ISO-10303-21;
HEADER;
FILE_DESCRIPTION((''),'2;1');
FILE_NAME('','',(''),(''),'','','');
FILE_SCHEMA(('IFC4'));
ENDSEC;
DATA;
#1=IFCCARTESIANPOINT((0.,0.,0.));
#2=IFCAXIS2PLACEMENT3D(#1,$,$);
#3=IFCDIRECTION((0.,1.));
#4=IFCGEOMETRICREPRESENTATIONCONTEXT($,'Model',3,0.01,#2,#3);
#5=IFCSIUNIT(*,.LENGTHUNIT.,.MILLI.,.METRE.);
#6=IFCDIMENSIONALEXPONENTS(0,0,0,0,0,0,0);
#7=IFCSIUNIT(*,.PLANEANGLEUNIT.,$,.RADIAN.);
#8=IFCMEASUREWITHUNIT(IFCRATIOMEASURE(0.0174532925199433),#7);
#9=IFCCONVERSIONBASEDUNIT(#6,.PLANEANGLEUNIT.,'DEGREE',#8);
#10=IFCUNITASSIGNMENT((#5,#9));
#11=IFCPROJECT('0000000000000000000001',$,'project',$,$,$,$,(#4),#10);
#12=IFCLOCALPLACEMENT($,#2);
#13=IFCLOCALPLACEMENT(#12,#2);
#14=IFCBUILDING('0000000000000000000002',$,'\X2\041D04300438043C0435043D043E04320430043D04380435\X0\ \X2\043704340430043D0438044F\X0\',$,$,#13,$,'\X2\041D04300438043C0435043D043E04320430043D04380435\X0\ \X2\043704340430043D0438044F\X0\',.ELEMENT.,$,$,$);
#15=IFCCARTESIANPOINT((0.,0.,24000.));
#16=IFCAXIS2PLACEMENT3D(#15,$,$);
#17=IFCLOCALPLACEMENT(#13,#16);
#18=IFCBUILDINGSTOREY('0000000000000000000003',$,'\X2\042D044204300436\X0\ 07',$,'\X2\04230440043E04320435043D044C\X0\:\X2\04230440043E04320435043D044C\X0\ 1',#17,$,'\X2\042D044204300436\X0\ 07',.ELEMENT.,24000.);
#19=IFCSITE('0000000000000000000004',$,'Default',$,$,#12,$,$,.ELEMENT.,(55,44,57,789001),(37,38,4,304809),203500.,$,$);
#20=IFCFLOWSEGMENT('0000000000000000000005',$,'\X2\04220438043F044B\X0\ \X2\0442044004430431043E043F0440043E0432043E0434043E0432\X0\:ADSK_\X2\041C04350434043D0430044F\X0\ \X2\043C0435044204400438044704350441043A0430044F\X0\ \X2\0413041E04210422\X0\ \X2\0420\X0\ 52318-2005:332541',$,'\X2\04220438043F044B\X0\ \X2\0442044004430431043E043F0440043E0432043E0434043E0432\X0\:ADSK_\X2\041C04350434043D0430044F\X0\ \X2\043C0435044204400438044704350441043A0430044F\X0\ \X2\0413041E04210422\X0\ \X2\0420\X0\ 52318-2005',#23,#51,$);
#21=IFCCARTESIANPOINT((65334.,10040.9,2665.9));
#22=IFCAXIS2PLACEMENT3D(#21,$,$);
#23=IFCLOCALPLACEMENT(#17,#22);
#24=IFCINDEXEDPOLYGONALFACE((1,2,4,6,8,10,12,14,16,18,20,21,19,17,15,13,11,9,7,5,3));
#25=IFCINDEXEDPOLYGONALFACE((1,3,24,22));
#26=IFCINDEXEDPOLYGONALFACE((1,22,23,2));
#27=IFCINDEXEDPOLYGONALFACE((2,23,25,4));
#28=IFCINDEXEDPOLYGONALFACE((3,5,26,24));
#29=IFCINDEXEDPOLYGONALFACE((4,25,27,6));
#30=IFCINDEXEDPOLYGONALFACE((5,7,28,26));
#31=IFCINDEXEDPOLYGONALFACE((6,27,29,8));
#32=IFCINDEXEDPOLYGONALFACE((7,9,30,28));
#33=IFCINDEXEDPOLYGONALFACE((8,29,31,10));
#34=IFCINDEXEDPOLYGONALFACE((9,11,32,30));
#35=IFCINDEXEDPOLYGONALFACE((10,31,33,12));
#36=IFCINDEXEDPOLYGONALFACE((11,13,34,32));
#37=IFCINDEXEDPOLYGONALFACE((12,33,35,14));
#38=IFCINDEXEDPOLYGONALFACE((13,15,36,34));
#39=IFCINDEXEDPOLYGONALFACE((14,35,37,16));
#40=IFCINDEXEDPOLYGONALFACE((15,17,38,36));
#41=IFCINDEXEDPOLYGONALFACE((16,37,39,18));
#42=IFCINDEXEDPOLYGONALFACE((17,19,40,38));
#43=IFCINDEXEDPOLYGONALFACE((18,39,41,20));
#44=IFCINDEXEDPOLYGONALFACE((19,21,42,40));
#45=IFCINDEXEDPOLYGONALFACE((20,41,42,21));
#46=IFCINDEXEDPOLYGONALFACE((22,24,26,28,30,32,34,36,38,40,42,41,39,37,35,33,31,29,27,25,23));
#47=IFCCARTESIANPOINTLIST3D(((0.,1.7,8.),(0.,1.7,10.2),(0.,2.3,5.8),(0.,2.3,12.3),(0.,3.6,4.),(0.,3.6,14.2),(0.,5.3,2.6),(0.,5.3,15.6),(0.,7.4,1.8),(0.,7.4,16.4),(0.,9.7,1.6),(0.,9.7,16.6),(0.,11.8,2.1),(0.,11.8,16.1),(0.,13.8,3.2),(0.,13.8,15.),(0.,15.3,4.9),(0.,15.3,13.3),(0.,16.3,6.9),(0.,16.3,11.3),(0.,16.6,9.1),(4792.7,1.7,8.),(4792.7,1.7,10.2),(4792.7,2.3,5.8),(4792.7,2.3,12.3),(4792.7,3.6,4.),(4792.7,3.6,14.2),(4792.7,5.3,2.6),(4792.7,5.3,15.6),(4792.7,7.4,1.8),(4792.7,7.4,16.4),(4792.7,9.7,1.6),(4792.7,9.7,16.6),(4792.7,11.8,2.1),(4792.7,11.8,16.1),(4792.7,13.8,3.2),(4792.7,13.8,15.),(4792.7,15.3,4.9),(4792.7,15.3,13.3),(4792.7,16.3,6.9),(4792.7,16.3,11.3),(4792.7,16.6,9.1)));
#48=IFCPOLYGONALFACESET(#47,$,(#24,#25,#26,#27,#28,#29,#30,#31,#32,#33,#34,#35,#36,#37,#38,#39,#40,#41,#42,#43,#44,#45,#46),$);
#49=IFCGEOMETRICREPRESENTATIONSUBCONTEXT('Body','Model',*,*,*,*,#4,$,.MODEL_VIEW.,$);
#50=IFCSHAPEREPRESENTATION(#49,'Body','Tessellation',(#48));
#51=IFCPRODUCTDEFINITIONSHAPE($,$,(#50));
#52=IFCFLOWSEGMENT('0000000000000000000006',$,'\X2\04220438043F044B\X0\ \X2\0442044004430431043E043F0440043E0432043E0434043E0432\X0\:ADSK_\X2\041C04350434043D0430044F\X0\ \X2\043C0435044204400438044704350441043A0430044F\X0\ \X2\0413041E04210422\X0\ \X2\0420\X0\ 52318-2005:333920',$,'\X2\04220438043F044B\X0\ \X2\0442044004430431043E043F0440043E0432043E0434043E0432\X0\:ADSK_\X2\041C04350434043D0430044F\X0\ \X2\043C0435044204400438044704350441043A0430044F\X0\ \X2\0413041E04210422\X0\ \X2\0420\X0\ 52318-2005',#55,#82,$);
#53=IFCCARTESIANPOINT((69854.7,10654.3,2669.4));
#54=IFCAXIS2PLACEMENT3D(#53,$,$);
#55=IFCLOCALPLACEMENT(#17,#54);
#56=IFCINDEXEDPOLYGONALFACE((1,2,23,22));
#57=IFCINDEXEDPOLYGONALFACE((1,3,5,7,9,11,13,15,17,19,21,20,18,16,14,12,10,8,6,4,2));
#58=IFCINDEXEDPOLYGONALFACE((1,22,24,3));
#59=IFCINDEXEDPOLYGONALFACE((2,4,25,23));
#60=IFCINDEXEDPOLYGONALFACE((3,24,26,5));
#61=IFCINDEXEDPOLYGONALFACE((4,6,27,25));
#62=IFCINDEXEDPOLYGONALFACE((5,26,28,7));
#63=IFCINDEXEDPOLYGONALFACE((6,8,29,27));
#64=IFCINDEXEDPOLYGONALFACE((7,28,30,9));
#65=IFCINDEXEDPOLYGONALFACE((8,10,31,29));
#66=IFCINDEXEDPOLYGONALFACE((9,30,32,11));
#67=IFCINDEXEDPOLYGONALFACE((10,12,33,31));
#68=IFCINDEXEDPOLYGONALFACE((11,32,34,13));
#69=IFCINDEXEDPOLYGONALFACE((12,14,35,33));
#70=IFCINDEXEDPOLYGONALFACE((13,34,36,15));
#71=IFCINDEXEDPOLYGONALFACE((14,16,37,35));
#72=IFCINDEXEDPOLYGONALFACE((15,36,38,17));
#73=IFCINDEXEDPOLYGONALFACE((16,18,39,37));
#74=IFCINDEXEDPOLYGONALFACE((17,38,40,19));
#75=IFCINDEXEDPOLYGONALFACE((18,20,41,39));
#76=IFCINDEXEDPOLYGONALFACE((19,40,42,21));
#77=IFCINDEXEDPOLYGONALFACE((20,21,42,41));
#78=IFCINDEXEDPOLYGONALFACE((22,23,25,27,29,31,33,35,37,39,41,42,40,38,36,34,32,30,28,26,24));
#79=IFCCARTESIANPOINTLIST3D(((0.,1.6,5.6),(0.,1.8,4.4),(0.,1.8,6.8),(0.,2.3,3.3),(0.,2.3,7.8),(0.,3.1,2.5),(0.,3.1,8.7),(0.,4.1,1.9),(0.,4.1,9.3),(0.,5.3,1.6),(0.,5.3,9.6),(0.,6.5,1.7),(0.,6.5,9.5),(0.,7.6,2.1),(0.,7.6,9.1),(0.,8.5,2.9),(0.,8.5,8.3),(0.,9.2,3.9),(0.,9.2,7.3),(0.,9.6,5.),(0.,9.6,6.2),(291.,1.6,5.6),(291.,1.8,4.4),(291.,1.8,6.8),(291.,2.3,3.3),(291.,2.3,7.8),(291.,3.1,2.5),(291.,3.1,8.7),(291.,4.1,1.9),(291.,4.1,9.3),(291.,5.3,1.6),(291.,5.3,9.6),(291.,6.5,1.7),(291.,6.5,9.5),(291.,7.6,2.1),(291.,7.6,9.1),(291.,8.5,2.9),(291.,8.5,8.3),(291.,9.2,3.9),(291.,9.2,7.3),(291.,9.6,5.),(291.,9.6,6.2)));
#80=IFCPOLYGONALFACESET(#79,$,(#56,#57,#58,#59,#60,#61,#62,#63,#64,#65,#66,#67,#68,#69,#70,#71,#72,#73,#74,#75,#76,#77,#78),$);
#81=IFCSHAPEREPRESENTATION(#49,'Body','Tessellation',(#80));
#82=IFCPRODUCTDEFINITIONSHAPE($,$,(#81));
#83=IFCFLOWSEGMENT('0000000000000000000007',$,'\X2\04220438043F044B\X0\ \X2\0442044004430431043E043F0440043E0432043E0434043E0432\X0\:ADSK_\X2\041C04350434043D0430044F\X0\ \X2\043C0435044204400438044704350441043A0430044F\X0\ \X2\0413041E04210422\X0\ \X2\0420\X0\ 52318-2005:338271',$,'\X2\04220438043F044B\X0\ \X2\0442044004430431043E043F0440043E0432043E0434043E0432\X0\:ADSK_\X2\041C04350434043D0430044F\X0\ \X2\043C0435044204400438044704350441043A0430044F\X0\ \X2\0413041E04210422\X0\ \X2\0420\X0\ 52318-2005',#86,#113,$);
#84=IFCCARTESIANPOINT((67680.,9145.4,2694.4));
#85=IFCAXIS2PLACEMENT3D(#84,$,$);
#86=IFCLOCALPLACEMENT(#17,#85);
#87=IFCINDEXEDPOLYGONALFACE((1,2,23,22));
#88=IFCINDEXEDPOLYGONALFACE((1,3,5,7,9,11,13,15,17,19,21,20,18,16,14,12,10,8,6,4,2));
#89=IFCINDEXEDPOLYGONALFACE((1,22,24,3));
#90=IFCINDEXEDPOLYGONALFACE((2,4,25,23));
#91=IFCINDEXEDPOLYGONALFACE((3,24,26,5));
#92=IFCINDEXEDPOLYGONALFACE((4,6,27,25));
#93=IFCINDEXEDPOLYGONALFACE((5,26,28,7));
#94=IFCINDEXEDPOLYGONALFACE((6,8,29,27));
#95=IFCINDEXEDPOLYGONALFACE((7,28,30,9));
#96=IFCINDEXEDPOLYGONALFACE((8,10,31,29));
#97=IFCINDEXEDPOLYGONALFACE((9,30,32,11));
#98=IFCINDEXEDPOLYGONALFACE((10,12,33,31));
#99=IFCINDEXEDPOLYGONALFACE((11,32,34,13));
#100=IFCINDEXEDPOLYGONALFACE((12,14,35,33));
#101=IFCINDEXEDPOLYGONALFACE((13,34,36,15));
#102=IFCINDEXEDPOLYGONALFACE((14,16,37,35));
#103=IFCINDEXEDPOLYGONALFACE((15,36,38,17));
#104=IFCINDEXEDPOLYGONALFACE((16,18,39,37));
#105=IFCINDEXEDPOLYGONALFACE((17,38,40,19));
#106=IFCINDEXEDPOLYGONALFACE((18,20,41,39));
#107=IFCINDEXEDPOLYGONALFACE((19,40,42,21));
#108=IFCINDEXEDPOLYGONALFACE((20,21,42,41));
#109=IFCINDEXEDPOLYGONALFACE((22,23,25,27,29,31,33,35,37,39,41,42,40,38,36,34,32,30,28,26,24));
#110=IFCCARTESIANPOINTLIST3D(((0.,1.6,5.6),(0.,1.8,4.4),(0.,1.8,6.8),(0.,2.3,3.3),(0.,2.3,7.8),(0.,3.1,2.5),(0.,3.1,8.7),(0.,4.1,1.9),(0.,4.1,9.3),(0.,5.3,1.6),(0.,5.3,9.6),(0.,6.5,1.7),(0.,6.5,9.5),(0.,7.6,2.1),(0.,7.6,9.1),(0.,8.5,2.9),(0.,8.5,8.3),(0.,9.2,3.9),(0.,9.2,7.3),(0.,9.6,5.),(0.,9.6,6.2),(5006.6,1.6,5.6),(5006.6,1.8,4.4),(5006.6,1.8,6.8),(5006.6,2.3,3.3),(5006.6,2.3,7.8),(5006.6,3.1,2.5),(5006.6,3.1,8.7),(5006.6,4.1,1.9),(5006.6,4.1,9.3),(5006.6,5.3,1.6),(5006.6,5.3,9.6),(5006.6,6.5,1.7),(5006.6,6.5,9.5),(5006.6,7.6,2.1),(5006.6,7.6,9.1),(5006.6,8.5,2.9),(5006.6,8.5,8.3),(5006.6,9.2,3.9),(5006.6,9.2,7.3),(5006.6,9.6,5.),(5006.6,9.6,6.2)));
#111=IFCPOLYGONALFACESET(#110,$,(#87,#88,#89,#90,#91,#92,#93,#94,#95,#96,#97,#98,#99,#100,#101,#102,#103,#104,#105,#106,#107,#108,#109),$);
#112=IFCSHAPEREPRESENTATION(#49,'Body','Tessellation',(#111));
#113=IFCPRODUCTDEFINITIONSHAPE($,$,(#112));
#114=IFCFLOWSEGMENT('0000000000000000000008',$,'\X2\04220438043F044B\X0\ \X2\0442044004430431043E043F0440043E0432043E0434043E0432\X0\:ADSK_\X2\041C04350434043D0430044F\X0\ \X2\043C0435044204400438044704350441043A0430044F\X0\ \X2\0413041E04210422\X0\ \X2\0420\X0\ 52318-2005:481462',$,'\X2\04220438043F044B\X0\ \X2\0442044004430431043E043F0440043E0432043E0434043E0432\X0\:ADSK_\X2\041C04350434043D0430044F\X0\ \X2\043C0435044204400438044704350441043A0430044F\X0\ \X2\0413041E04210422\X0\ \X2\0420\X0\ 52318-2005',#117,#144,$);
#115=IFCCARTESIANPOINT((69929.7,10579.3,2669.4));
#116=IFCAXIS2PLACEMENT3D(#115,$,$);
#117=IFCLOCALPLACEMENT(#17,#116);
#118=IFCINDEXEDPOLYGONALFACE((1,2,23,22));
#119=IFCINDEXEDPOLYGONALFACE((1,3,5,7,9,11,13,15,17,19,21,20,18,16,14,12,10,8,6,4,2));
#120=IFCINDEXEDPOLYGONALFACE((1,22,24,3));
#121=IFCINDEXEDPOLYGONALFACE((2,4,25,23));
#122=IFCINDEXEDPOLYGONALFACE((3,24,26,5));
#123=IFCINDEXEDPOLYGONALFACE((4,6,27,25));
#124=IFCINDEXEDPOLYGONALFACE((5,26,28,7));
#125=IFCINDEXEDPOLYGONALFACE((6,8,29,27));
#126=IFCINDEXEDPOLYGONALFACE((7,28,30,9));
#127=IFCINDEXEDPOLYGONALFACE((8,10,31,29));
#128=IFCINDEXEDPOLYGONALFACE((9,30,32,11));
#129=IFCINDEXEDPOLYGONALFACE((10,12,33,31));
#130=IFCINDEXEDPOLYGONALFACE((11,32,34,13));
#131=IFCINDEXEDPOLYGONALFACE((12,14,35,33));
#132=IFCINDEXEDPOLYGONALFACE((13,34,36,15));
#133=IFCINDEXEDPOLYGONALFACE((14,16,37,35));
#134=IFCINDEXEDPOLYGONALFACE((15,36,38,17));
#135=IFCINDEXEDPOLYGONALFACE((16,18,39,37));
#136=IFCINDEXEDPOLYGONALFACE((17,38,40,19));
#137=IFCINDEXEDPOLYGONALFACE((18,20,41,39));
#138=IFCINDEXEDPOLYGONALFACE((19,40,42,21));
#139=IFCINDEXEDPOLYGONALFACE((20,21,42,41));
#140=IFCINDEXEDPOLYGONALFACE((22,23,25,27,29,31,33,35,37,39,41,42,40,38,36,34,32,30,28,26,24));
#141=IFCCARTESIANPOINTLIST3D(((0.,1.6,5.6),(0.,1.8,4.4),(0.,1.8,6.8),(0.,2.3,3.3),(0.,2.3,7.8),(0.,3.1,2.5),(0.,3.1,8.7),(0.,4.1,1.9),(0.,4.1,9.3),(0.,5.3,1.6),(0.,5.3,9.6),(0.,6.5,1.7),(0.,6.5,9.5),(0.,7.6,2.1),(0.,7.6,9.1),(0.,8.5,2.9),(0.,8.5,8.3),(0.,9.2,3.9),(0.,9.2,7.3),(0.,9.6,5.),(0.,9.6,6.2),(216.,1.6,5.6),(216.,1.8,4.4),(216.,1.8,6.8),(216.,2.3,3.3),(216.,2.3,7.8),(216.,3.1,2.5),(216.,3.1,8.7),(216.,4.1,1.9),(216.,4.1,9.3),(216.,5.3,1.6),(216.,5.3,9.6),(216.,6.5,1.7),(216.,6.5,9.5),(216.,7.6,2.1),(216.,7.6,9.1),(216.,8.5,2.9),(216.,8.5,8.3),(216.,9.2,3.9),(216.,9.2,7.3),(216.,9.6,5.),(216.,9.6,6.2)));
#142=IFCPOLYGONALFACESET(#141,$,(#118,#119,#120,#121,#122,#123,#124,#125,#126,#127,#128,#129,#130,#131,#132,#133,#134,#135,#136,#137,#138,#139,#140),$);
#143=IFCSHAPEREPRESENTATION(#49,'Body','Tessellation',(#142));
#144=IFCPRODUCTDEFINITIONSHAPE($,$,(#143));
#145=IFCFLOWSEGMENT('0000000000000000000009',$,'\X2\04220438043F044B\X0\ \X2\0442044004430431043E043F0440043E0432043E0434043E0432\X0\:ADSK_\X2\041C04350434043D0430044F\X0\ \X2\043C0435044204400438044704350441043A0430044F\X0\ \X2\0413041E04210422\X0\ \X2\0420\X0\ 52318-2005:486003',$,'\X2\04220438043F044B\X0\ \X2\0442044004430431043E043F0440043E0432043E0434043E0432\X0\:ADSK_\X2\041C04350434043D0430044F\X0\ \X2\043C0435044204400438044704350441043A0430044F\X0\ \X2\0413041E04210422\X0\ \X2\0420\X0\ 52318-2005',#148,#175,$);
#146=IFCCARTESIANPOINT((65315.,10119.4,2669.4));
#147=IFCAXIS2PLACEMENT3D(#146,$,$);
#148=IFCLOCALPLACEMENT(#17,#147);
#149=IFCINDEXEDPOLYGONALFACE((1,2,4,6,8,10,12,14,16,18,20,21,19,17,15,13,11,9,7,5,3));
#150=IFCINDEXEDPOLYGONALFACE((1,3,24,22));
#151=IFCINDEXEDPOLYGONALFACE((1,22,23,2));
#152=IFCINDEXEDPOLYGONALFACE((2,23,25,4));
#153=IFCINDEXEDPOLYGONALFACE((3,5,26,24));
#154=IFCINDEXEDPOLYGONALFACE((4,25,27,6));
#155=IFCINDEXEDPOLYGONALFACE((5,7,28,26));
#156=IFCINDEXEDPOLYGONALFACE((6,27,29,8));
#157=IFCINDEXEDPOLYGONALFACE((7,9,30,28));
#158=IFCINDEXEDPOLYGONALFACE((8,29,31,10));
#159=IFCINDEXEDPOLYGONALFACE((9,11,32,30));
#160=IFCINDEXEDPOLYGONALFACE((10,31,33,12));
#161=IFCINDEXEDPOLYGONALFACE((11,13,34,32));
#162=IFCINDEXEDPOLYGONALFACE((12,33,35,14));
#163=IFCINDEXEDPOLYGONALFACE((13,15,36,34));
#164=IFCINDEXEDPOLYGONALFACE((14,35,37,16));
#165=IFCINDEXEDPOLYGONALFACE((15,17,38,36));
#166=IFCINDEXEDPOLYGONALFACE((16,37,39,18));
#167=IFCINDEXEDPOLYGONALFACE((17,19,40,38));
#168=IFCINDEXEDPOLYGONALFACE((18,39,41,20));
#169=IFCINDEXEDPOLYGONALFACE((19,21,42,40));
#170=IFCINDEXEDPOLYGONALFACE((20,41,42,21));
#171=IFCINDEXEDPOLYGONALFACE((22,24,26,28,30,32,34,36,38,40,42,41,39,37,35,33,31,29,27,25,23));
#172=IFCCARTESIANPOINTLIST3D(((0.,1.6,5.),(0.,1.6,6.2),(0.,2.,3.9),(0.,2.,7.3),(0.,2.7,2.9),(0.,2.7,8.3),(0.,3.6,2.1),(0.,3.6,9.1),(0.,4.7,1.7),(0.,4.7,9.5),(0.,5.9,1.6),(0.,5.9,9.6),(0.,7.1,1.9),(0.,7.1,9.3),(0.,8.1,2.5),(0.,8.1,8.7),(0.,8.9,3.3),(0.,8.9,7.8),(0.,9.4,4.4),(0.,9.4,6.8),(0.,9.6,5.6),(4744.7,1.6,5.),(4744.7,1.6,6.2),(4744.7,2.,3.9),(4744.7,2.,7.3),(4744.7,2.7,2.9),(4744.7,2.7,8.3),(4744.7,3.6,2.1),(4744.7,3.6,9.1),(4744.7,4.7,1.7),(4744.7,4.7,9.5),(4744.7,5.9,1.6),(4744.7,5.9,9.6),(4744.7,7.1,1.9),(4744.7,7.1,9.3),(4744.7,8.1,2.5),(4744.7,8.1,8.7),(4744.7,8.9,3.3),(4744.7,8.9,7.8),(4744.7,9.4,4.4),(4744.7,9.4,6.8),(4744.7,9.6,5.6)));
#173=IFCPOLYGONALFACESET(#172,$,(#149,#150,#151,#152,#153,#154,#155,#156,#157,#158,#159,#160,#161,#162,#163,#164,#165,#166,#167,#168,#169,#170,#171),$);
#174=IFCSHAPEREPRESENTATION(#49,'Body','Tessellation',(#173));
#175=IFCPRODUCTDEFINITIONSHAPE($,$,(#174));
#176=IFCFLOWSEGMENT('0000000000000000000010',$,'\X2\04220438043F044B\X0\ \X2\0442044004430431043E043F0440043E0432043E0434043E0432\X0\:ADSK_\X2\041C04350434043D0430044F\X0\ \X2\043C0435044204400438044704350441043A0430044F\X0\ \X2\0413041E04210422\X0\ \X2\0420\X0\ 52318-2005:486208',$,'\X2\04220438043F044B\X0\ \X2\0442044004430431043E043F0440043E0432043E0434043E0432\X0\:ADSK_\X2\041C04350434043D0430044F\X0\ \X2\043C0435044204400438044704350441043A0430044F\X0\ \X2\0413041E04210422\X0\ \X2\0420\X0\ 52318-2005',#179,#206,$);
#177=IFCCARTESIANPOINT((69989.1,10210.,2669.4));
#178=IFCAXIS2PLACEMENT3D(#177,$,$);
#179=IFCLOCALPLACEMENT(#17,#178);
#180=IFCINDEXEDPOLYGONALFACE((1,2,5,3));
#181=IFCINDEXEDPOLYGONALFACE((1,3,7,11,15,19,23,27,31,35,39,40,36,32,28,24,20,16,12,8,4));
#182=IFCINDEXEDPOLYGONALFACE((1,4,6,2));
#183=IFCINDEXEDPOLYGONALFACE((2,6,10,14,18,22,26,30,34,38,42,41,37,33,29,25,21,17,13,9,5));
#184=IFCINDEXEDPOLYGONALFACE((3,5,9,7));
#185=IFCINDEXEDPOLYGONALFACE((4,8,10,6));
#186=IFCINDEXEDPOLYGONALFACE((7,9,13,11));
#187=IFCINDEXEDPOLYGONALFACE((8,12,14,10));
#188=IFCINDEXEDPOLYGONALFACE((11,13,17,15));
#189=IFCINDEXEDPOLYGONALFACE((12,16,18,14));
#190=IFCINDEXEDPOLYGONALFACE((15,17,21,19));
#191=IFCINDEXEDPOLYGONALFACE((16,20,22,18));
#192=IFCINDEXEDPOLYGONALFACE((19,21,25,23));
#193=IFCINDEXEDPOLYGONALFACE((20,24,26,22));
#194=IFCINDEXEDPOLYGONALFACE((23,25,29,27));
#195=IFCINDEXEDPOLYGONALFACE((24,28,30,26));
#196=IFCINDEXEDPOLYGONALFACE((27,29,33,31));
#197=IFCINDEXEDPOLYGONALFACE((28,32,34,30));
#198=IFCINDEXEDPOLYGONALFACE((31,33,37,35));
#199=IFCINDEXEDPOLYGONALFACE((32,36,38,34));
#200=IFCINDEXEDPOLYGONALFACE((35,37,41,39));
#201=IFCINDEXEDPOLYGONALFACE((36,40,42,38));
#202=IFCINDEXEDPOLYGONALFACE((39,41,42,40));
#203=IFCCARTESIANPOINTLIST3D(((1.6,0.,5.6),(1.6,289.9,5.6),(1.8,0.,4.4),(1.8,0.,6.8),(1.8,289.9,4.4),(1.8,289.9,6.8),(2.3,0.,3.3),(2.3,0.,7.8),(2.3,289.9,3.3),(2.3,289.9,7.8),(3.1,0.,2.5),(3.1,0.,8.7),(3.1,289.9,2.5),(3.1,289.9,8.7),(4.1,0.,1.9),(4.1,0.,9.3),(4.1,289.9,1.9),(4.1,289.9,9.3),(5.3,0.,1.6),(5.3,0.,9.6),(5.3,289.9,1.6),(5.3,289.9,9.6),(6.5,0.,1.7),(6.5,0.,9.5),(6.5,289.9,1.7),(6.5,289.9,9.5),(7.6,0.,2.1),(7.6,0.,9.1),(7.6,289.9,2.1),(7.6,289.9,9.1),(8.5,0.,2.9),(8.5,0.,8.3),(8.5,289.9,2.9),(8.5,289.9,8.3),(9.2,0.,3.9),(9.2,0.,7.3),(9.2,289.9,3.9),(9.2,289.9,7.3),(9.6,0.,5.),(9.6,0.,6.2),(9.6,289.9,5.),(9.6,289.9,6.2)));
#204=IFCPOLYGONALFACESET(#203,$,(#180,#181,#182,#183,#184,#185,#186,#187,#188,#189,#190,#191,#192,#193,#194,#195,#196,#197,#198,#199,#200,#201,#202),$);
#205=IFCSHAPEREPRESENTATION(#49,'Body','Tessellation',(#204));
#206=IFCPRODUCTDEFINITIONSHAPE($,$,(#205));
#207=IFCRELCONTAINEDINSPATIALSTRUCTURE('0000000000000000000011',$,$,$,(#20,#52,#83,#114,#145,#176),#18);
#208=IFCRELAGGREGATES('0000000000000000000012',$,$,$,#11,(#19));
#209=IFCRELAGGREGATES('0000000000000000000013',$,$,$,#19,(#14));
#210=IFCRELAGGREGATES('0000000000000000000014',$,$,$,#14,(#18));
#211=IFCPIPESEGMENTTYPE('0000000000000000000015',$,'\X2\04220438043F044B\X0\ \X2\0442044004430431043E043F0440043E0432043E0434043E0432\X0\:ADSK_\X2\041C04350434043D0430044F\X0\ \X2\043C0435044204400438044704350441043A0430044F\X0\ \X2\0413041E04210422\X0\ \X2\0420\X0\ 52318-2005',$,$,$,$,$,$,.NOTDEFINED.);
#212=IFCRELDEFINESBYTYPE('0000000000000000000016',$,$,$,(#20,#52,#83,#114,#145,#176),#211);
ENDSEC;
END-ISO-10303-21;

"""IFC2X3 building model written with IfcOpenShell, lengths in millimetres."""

from ifc_helpers import new_model, entity, si_unit, converted_unit, direction, frame, frame_2d, origin, origin_2d_with_axis, place, context, subcontext, project, spatial, circle, extrude, type_object, element, save


model = new_model("IFC2X3")

# Units and contexts
model_context = context("Model", 3, precision=0.01, world=origin(), true_north=direction((0.0, 1.0)))
body_context = subcontext(model_context, "Body", "Model", "MODEL_VIEW")
ifc_project = project(units=[si_unit("LENGTHUNIT", "METRE", prefix="MILLI"), converted_unit("PLANEANGLEUNIT", "DEGREE", entity("IfcRatioMeasure", 0.0174532925199433), si_unit("PLANEANGLEUNIT", "RADIAN"), dimensions=[0, 0, 0, 0, 0, 0, 0])], contexts=[model_context])

# Site, building, storey
site_placement = place(None, frame((0.0, 0.0, 0.0)))
site = spatial("IfcSite", under=ifc_project, at=site_placement, Name="Default", CompositionType="ELEMENT", RefLatitude=(55, 44, 57, 789001), RefLongitude=(37, 38, 4, 304809), RefElevation=203500.0)
building_placement = place(site_placement, origin())
building = spatial("IfcBuilding", under=site, at=building_placement, Name="Наименование здания", LongName="Наименование здания", CompositionType="ELEMENT")
storey_placement = place(building_placement, frame((0.0, 0.0, 24000.0)))
storey = spatial("IfcBuildingStorey", under=building, at=storey_placement, Name="Этаж 07", ObjectType="Уровень:Уровень 1", LongName="Этаж 07", CompositionType="ELEMENT", Elevation=24000.0)

# Flow segments
pipe_segment_type = type_object("IfcPipeSegmentType", Name="Типы трубопроводов:ADSK_Медная метрическая ГОСТ Р 52318-2005", PredefinedType="NOTDEFINED")
flow_segment_1_placement = place(storey_placement, frame((65334.0, 10040.9, 2665.9)))
element("IfcFlowSegment", 1, at=flow_segment_1_placement, inside=storey, type_object=pipe_segment_type, Name="Типы трубопроводов:ADSK_Медная метрическая ГОСТ Р 52318-2005:332541", ObjectType="Типы трубопроводов:ADSK_Медная метрическая ГОСТ Р 52318-2005", context=body_context, shape_type="SweptSolid", body=[
    extrude(circle(Radius=7.5, at=frame_2d((0.0, 0.0), x_axis=(1.0, 0.0))), frame((0.0, 9.1, 9.1), z_axis=(1.0, 0.0, 0.0), x_axis=(0.0, 1.0, 0.0)), (0.0, 0.0, 1.0), 4792.7),
])
flow_segment_2_placement = place(storey_placement, frame((69854.7, 10654.3, 2669.4)))
element("IfcFlowSegment", 2, at=flow_segment_2_placement, inside=storey, type_object=pipe_segment_type, Name="Типы трубопроводов:ADSK_Медная метрическая ГОСТ Р 52318-2005:333920", ObjectType="Типы трубопроводов:ADSK_Медная метрическая ГОСТ Р 52318-2005", context=body_context, shape_type="SweptSolid", body=[
    extrude(circle(Radius=4.0, at=origin_2d_with_axis()), frame((0.0, 5.6, 5.6), z_axis=(1.0, 0.0, 0.0), x_axis=(0.0, -1.0, 0.0)), (0.0, 0.0, 1.0), 291.0),
])
flow_segment_3_placement = place(storey_placement, frame((67680.0, 9145.4, 2694.4)))
element("IfcFlowSegment", 3, at=flow_segment_3_placement, inside=storey, type_object=pipe_segment_type, Name="Типы трубопроводов:ADSK_Медная метрическая ГОСТ Р 52318-2005:338271", ObjectType="Типы трубопроводов:ADSK_Медная метрическая ГОСТ Р 52318-2005", context=body_context, shape_type="SweptSolid", body=[
    extrude(circle(Radius=4.0, at=origin_2d_with_axis()), frame((0.0, 5.6, 5.6), z_axis=(1.0, 0.0, 0.0), x_axis=(0.0, -1.0, 0.0)), (0.0, 0.0, 1.0), 5006.6),
])
flow_segment_4_placement = place(storey_placement, frame((69929.7, 10579.3, 2669.4)))
element("IfcFlowSegment", 4, at=flow_segment_4_placement, inside=storey, type_object=pipe_segment_type, Name="Типы трубопроводов:ADSK_Медная метрическая ГОСТ Р 52318-2005:481462", ObjectType="Типы трубопроводов:ADSK_Медная метрическая ГОСТ Р 52318-2005", context=body_context, shape_type="SweptSolid", body=[
    extrude(circle(Radius=4.0, at=origin_2d_with_axis()), frame((0.0, 5.6, 5.6), z_axis=(1.0, 0.0, 0.0), x_axis=(0.0, -1.0, 0.0)), (0.0, 0.0, 1.0), 216.0),
])
flow_segment_5_placement = place(storey_placement, frame((65315.0, 10119.4, 2669.4)))
element("IfcFlowSegment", 5, at=flow_segment_5_placement, inside=storey, type_object=pipe_segment_type, Name="Типы трубопроводов:ADSK_Медная метрическая ГОСТ Р 52318-2005:486003", ObjectType="Типы трубопроводов:ADSK_Медная метрическая ГОСТ Р 52318-2005", context=body_context, shape_type="SweptSolid", body=[
    extrude(circle(Radius=4.0, at=frame_2d((0.0, 0.0), x_axis=(1.0, 0.0))), frame((0.0, 5.6, 5.6), z_axis=(1.0, 0.0, 0.0), x_axis=(0.0, 1.0, 0.0)), (0.0, 0.0, 1.0), 4744.7),
])
flow_segment_6_placement = place(storey_placement, frame((69989.1, 10210.0, 2669.4)))
element("IfcFlowSegment", 6, at=flow_segment_6_placement, inside=storey, type_object=pipe_segment_type, Name="Типы трубопроводов:ADSK_Медная метрическая ГОСТ Р 52318-2005:486208", ObjectType="Типы трубопроводов:ADSK_Медная метрическая ГОСТ Р 52318-2005", context=body_context, shape_type="SweptSolid", body=[
    extrude(circle(Radius=4.0, at=frame_2d((0.0, 0.0), x_axis=(1.0, 0.0))), frame((5.6, 0.0, 5.6), z_axis=(0.0, 1.0, 0.0), x_axis=(-1.0, 0.0, 0.0)), (0.0, 0.0, 1.0), 289.9),
])

save(model, "model.ifc")
